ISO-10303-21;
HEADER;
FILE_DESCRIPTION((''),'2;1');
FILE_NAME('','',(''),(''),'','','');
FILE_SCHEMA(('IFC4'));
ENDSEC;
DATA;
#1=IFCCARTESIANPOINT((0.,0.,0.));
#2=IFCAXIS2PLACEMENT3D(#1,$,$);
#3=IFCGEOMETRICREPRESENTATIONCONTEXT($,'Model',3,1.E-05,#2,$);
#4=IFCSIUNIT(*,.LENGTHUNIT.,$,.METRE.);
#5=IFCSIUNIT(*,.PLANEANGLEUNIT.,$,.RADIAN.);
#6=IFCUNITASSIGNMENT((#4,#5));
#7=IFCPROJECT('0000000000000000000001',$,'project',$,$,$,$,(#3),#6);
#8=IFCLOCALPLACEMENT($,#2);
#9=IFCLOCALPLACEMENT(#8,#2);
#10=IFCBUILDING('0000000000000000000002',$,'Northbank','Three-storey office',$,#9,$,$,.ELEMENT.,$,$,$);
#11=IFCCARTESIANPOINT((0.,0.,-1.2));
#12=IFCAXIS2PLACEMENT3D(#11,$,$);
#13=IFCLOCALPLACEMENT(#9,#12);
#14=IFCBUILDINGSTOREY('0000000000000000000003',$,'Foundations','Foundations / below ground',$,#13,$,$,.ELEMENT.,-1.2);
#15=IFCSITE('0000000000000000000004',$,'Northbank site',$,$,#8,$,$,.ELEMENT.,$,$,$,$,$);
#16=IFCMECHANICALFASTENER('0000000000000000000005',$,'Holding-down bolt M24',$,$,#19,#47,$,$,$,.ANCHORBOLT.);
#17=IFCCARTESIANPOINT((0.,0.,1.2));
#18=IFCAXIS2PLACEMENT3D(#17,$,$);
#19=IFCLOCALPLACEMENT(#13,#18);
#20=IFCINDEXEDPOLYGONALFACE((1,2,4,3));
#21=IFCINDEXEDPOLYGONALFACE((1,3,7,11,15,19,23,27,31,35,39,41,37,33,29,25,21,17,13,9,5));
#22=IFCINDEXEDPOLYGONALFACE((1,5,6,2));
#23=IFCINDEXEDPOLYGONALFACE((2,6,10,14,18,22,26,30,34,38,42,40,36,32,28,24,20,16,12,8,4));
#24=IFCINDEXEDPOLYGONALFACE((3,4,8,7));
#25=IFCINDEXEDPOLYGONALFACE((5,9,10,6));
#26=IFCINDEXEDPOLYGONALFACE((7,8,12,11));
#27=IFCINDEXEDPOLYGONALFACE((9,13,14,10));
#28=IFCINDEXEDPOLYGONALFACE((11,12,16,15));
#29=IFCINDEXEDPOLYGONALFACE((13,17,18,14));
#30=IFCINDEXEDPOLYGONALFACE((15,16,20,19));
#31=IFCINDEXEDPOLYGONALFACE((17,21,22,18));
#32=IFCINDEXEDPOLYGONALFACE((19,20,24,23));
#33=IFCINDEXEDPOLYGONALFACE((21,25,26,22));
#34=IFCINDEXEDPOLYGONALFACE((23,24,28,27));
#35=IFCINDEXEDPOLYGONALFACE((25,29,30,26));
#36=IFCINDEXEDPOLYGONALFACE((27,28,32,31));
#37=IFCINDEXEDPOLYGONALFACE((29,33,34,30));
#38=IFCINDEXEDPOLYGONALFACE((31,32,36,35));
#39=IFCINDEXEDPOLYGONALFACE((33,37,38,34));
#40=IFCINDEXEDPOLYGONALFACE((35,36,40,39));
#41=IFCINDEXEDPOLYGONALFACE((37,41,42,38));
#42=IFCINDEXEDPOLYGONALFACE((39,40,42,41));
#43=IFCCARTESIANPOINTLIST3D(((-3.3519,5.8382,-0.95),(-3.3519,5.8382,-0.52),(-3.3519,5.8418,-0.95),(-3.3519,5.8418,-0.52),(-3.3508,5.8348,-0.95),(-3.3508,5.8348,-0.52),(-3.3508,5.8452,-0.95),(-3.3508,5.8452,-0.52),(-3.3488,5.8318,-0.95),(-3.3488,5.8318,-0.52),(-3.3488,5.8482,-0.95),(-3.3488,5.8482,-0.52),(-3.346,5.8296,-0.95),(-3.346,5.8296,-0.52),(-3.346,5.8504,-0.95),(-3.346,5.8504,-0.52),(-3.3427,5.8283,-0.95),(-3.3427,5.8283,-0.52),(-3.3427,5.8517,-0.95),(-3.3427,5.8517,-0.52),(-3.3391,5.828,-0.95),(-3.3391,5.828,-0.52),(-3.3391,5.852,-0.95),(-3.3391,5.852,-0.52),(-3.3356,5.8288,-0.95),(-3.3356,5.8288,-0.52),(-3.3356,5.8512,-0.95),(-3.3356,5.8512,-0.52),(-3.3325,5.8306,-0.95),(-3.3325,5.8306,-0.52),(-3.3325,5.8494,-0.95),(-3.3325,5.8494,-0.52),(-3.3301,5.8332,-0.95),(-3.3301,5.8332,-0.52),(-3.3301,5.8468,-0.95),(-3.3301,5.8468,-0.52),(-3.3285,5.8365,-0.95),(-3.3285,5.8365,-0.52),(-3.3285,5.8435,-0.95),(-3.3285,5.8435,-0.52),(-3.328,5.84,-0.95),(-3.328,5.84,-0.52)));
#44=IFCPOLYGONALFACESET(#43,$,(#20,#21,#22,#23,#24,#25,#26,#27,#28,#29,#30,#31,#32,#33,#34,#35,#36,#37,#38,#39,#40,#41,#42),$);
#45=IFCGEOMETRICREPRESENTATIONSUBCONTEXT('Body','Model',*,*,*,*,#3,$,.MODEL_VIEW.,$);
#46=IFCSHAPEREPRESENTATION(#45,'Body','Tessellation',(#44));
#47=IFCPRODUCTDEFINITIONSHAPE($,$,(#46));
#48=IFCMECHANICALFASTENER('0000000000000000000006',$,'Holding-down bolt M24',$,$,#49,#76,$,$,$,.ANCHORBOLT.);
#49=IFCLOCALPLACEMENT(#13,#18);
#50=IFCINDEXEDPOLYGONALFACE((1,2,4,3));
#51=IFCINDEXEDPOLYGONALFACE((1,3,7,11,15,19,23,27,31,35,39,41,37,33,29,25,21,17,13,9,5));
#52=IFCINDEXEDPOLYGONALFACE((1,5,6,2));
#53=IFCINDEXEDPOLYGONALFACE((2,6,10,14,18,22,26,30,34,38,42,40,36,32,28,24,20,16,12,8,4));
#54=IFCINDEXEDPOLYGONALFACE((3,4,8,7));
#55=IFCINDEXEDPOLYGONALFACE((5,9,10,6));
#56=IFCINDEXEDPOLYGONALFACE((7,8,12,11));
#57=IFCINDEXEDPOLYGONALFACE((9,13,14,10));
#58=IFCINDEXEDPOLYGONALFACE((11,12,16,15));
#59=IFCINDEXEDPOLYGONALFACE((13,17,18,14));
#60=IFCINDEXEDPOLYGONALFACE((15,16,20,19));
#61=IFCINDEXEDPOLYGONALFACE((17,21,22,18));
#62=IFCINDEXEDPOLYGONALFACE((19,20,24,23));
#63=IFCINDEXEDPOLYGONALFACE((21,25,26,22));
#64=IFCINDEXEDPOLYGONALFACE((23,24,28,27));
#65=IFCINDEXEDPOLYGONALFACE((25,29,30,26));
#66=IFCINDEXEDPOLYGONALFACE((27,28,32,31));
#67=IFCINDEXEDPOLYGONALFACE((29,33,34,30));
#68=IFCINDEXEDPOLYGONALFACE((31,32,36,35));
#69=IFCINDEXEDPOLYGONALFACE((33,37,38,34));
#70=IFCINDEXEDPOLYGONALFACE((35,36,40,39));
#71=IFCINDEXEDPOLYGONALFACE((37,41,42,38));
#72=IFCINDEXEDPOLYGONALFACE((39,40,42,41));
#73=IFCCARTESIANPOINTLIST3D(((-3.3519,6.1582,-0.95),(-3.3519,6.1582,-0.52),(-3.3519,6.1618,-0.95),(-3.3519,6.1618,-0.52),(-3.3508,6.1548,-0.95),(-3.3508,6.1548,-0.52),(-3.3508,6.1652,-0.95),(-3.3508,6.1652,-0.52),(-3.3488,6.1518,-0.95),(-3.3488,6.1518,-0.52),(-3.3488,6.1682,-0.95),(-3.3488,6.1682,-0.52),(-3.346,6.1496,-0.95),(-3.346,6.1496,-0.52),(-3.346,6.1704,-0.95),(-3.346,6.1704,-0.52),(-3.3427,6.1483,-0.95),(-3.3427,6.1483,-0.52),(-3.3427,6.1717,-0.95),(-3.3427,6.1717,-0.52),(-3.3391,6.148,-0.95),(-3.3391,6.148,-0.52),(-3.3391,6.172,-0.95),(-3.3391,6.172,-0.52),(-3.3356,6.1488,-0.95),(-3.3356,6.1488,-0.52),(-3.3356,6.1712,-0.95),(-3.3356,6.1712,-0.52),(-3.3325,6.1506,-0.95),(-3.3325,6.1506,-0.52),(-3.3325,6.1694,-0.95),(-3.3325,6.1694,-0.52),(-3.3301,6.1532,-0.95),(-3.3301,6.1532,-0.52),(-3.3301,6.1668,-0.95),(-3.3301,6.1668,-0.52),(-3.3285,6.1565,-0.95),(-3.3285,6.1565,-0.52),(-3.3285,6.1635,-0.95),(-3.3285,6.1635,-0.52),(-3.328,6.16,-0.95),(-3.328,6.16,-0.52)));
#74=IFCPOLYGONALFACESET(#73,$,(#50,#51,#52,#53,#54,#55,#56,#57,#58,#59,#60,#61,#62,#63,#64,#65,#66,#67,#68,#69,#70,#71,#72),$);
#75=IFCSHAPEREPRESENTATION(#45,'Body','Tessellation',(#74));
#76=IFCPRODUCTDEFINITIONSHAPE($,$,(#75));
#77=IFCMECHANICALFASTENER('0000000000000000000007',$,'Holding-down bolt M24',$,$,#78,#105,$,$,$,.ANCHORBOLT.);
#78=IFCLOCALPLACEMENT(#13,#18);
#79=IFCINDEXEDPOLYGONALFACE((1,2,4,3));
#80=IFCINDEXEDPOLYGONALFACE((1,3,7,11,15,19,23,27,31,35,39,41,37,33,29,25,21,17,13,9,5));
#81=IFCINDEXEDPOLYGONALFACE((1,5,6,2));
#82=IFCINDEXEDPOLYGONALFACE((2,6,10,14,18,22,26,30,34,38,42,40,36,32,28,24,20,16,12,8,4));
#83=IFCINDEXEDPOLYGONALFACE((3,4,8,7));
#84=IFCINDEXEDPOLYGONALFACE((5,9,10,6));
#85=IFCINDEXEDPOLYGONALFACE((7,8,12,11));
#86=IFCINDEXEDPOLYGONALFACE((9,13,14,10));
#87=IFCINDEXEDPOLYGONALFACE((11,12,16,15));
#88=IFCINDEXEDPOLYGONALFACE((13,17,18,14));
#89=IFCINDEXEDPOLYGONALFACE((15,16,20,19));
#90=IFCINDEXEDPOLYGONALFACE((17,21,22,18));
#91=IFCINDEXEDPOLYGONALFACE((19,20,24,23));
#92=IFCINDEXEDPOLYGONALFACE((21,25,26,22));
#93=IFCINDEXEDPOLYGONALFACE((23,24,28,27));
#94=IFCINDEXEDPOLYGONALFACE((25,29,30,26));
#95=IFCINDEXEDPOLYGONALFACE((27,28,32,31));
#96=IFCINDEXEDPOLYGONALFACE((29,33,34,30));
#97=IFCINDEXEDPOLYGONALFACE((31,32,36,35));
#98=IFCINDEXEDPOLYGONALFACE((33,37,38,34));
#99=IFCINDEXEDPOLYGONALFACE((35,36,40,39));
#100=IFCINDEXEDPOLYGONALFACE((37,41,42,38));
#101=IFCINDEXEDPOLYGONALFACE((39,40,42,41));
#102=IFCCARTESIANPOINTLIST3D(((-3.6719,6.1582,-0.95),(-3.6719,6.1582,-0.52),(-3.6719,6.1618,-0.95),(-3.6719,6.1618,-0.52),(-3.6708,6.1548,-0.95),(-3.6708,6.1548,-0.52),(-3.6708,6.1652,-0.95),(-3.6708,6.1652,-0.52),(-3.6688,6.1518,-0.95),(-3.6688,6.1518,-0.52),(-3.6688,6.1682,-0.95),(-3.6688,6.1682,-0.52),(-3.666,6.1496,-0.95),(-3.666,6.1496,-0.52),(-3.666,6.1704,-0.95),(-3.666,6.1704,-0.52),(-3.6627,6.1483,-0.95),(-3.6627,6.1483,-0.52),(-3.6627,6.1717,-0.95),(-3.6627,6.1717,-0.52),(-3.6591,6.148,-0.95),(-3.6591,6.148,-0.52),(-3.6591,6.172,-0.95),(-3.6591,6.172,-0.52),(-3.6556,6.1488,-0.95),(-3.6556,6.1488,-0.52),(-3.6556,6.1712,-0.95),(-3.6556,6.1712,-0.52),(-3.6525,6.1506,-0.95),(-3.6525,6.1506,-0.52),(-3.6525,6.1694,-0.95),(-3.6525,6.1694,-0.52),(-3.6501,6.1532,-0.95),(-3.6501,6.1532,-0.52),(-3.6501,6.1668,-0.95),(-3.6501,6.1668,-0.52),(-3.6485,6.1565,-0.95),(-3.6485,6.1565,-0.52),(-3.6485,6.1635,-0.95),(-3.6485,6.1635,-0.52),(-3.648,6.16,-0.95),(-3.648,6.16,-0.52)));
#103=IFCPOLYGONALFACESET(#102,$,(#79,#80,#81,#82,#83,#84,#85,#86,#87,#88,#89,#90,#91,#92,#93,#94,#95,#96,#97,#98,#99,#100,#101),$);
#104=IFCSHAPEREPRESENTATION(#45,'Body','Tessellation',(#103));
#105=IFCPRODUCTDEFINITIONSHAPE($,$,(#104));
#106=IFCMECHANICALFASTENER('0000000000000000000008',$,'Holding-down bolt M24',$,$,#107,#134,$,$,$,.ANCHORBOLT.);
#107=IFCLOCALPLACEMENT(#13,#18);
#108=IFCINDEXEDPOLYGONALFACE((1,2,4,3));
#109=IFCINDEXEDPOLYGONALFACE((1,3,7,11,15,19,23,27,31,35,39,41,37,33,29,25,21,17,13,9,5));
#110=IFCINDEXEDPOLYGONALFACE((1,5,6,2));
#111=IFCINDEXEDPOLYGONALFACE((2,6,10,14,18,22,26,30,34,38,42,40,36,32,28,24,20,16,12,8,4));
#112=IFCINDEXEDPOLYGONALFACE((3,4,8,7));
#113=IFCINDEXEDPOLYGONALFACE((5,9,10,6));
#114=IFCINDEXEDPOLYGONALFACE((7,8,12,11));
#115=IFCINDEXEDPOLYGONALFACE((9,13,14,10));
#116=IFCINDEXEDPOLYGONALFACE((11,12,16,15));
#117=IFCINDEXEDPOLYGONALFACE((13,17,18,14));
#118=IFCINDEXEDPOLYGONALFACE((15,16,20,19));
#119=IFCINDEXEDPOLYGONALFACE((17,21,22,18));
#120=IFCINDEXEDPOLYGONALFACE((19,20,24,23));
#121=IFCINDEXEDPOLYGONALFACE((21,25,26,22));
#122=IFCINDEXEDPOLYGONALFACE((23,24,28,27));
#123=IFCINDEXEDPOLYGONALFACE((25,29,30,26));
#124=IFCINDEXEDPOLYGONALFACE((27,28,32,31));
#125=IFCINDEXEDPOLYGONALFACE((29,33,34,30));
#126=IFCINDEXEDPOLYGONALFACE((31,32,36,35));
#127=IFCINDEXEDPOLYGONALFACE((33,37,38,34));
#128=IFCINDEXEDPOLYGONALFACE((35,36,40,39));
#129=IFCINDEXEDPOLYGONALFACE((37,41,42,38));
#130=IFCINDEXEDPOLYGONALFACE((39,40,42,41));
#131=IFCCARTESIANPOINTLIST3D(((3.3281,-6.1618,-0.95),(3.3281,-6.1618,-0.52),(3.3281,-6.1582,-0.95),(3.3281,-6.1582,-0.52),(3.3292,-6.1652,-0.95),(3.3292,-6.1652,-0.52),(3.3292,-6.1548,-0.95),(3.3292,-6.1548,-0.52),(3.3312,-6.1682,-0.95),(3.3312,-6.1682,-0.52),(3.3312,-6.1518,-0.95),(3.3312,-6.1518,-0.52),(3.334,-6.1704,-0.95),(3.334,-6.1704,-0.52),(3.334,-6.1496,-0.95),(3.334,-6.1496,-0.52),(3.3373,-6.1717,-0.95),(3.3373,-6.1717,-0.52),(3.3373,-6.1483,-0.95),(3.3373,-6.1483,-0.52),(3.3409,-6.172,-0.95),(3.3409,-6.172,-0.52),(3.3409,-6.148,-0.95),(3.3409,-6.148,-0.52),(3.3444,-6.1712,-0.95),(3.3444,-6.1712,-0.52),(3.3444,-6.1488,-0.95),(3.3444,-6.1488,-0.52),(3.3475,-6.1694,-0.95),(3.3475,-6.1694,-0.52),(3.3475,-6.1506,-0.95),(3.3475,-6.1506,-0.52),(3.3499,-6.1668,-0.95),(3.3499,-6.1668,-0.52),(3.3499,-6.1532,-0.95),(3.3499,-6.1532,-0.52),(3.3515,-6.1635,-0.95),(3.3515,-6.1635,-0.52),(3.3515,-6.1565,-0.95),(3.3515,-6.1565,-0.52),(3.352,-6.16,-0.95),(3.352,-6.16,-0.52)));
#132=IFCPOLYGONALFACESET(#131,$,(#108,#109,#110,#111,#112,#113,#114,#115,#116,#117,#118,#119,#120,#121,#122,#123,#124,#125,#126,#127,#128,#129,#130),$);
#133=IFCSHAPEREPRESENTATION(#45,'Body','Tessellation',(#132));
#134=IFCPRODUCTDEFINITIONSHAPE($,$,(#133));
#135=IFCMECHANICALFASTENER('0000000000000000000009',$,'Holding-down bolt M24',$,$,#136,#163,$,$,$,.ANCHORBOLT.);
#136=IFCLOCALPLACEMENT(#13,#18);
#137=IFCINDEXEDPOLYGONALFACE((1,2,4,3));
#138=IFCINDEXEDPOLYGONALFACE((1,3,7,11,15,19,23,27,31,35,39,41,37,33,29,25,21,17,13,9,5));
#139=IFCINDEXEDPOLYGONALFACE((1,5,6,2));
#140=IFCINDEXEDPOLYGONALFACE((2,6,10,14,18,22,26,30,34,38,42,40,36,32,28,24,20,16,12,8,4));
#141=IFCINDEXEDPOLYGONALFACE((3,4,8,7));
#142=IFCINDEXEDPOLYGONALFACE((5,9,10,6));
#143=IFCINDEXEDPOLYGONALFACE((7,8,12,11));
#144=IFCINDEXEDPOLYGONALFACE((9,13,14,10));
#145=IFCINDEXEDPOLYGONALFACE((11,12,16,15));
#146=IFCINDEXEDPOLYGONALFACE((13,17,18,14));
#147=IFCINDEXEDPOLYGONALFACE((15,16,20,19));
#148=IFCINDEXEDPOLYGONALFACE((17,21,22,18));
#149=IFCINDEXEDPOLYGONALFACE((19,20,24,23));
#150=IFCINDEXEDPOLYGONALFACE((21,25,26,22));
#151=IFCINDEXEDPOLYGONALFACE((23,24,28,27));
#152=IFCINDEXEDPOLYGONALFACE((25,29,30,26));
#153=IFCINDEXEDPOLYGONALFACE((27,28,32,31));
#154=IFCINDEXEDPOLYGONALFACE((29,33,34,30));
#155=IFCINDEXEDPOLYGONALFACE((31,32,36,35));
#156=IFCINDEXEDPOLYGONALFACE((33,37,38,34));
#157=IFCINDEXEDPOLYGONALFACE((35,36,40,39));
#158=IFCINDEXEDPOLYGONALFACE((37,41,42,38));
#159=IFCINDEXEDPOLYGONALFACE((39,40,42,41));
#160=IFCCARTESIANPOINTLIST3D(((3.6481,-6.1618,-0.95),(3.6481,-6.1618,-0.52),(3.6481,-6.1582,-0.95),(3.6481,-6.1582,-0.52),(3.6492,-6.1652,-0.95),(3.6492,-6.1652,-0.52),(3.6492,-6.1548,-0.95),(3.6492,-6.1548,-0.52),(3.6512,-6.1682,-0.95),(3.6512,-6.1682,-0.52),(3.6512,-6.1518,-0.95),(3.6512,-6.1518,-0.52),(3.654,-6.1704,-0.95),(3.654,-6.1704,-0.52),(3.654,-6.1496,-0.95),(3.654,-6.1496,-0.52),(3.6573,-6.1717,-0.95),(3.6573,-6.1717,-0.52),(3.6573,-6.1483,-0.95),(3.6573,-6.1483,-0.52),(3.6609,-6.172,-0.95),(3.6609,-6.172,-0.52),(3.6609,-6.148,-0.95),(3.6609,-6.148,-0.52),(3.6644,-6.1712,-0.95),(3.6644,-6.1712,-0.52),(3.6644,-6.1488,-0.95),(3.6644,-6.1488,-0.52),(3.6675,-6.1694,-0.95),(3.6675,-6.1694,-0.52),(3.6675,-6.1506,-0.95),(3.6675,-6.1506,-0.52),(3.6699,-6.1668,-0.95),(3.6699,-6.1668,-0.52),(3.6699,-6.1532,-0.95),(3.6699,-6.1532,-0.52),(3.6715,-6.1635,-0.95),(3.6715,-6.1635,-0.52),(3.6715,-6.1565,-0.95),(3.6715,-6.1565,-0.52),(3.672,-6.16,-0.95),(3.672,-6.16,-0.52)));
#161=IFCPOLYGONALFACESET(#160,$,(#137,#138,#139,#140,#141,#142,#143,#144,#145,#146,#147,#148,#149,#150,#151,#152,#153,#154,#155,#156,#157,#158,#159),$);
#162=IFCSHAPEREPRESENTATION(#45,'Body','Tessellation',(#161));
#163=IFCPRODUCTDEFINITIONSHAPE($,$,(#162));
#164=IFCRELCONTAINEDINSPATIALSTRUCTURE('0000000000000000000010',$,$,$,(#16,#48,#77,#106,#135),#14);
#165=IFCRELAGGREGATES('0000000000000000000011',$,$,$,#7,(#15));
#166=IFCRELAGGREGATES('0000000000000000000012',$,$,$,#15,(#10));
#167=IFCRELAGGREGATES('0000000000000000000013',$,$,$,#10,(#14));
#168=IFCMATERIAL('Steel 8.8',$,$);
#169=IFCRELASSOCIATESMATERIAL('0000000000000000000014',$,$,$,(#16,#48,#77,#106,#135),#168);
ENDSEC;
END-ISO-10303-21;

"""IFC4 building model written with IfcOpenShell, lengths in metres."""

from ifc_helpers import new_model, si_unit, frame, origin, place, context, subcontext, project, spatial, circle, extrude, material, element, save


model = new_model("IFC4")

# Units and contexts
model_context = context("Model", 3, precision=1e-05, world=origin())
body_context = subcontext(model_context, "Body", "Model", "MODEL_VIEW")
ifc_project = project(units=[si_unit("LENGTHUNIT", "METRE"), si_unit("PLANEANGLEUNIT", "RADIAN")], contexts=[model_context])

# Site, building, storey
site_placement = place(None, origin())
site = spatial("IfcSite", under=ifc_project, at=site_placement, Name="Northbank site", CompositionType="ELEMENT")
building_placement = place(site_placement, origin())
building = spatial("IfcBuilding", under=site, at=building_placement, Name="Northbank", Description="Three-storey office", CompositionType="ELEMENT")
storey_placement = place(building_placement, frame((0.0, 0.0, -1.2)))
storey = spatial("IfcBuildingStorey", under=building, at=storey_placement, Name="Foundations", Description="Foundations / below ground", CompositionType="ELEMENT", Elevation=-1.2)

# Mechanical fasteners
ifc_material_1 = material(Name="Steel 8.8")
mechanical_fastener_1_placement = place(storey_placement, frame((0.0, 0.0, 1.2)))
element("IfcMechanicalFastener", 1, at=mechanical_fastener_1_placement, inside=storey, material=ifc_material_1, Name="Holding-down bolt M24", PredefinedType="ANCHORBOLT", context=body_context, shape_type="SweptSolid", body=[
    extrude(circle(Radius=0.012), frame((-3.34, 5.84, -0.95), z_axis=(0.0, 0.0, 1.0), x_axis=(1.0, 0.0, 0.0)), (0.0, 0.0, 1.0), 0.43),
])
mechanical_fastener_2_placement = place(storey_placement, frame((0.0, 0.0, 1.2)))
element("IfcMechanicalFastener", 2, at=mechanical_fastener_2_placement, inside=storey, material=ifc_material_1, Name="Holding-down bolt M24", PredefinedType="ANCHORBOLT", context=body_context, shape_type="SweptSolid", body=[
    extrude(circle(Radius=0.012), frame((-3.34, 6.16, -0.95), z_axis=(0.0, 0.0, 1.0), x_axis=(1.0, 0.0, 0.0)), (0.0, 0.0, 1.0), 0.43),
])
mechanical_fastener_3_placement = place(storey_placement, frame((0.0, 0.0, 1.2)))
element("IfcMechanicalFastener", 3, at=mechanical_fastener_3_placement, inside=storey, material=ifc_material_1, Name="Holding-down bolt M24", PredefinedType="ANCHORBOLT", context=body_context, shape_type="SweptSolid", body=[
    extrude(circle(Radius=0.012), frame((-3.66, 6.16, -0.95), z_axis=(0.0, 0.0, 1.0), x_axis=(1.0, 0.0, 0.0)), (0.0, 0.0, 1.0), 0.43),
])
mechanical_fastener_4_placement = place(storey_placement, frame((0.0, 0.0, 1.2)))
element("IfcMechanicalFastener", 4, at=mechanical_fastener_4_placement, inside=storey, material=ifc_material_1, Name="Holding-down bolt M24", PredefinedType="ANCHORBOLT", context=body_context, shape_type="SweptSolid", body=[
    extrude(circle(Radius=0.012), frame((3.34, -6.16, -0.95), z_axis=(0.0, 0.0, 1.0), x_axis=(1.0, 0.0, 0.0)), (0.0, 0.0, 1.0), 0.43),
])
mechanical_fastener_5_placement = place(storey_placement, frame((0.0, 0.0, 1.2)))
element("IfcMechanicalFastener", 5, at=mechanical_fastener_5_placement, inside=storey, material=ifc_material_1, Name="Holding-down bolt M24", PredefinedType="ANCHORBOLT", context=body_context, shape_type="SweptSolid", body=[
    extrude(circle(Radius=0.012), frame((3.66, -6.16, -0.95), z_axis=(0.0, 0.0, 1.0), x_axis=(1.0, 0.0, 0.0)), (0.0, 0.0, 1.0), 0.43),
])

save(model, "model.ifc")
